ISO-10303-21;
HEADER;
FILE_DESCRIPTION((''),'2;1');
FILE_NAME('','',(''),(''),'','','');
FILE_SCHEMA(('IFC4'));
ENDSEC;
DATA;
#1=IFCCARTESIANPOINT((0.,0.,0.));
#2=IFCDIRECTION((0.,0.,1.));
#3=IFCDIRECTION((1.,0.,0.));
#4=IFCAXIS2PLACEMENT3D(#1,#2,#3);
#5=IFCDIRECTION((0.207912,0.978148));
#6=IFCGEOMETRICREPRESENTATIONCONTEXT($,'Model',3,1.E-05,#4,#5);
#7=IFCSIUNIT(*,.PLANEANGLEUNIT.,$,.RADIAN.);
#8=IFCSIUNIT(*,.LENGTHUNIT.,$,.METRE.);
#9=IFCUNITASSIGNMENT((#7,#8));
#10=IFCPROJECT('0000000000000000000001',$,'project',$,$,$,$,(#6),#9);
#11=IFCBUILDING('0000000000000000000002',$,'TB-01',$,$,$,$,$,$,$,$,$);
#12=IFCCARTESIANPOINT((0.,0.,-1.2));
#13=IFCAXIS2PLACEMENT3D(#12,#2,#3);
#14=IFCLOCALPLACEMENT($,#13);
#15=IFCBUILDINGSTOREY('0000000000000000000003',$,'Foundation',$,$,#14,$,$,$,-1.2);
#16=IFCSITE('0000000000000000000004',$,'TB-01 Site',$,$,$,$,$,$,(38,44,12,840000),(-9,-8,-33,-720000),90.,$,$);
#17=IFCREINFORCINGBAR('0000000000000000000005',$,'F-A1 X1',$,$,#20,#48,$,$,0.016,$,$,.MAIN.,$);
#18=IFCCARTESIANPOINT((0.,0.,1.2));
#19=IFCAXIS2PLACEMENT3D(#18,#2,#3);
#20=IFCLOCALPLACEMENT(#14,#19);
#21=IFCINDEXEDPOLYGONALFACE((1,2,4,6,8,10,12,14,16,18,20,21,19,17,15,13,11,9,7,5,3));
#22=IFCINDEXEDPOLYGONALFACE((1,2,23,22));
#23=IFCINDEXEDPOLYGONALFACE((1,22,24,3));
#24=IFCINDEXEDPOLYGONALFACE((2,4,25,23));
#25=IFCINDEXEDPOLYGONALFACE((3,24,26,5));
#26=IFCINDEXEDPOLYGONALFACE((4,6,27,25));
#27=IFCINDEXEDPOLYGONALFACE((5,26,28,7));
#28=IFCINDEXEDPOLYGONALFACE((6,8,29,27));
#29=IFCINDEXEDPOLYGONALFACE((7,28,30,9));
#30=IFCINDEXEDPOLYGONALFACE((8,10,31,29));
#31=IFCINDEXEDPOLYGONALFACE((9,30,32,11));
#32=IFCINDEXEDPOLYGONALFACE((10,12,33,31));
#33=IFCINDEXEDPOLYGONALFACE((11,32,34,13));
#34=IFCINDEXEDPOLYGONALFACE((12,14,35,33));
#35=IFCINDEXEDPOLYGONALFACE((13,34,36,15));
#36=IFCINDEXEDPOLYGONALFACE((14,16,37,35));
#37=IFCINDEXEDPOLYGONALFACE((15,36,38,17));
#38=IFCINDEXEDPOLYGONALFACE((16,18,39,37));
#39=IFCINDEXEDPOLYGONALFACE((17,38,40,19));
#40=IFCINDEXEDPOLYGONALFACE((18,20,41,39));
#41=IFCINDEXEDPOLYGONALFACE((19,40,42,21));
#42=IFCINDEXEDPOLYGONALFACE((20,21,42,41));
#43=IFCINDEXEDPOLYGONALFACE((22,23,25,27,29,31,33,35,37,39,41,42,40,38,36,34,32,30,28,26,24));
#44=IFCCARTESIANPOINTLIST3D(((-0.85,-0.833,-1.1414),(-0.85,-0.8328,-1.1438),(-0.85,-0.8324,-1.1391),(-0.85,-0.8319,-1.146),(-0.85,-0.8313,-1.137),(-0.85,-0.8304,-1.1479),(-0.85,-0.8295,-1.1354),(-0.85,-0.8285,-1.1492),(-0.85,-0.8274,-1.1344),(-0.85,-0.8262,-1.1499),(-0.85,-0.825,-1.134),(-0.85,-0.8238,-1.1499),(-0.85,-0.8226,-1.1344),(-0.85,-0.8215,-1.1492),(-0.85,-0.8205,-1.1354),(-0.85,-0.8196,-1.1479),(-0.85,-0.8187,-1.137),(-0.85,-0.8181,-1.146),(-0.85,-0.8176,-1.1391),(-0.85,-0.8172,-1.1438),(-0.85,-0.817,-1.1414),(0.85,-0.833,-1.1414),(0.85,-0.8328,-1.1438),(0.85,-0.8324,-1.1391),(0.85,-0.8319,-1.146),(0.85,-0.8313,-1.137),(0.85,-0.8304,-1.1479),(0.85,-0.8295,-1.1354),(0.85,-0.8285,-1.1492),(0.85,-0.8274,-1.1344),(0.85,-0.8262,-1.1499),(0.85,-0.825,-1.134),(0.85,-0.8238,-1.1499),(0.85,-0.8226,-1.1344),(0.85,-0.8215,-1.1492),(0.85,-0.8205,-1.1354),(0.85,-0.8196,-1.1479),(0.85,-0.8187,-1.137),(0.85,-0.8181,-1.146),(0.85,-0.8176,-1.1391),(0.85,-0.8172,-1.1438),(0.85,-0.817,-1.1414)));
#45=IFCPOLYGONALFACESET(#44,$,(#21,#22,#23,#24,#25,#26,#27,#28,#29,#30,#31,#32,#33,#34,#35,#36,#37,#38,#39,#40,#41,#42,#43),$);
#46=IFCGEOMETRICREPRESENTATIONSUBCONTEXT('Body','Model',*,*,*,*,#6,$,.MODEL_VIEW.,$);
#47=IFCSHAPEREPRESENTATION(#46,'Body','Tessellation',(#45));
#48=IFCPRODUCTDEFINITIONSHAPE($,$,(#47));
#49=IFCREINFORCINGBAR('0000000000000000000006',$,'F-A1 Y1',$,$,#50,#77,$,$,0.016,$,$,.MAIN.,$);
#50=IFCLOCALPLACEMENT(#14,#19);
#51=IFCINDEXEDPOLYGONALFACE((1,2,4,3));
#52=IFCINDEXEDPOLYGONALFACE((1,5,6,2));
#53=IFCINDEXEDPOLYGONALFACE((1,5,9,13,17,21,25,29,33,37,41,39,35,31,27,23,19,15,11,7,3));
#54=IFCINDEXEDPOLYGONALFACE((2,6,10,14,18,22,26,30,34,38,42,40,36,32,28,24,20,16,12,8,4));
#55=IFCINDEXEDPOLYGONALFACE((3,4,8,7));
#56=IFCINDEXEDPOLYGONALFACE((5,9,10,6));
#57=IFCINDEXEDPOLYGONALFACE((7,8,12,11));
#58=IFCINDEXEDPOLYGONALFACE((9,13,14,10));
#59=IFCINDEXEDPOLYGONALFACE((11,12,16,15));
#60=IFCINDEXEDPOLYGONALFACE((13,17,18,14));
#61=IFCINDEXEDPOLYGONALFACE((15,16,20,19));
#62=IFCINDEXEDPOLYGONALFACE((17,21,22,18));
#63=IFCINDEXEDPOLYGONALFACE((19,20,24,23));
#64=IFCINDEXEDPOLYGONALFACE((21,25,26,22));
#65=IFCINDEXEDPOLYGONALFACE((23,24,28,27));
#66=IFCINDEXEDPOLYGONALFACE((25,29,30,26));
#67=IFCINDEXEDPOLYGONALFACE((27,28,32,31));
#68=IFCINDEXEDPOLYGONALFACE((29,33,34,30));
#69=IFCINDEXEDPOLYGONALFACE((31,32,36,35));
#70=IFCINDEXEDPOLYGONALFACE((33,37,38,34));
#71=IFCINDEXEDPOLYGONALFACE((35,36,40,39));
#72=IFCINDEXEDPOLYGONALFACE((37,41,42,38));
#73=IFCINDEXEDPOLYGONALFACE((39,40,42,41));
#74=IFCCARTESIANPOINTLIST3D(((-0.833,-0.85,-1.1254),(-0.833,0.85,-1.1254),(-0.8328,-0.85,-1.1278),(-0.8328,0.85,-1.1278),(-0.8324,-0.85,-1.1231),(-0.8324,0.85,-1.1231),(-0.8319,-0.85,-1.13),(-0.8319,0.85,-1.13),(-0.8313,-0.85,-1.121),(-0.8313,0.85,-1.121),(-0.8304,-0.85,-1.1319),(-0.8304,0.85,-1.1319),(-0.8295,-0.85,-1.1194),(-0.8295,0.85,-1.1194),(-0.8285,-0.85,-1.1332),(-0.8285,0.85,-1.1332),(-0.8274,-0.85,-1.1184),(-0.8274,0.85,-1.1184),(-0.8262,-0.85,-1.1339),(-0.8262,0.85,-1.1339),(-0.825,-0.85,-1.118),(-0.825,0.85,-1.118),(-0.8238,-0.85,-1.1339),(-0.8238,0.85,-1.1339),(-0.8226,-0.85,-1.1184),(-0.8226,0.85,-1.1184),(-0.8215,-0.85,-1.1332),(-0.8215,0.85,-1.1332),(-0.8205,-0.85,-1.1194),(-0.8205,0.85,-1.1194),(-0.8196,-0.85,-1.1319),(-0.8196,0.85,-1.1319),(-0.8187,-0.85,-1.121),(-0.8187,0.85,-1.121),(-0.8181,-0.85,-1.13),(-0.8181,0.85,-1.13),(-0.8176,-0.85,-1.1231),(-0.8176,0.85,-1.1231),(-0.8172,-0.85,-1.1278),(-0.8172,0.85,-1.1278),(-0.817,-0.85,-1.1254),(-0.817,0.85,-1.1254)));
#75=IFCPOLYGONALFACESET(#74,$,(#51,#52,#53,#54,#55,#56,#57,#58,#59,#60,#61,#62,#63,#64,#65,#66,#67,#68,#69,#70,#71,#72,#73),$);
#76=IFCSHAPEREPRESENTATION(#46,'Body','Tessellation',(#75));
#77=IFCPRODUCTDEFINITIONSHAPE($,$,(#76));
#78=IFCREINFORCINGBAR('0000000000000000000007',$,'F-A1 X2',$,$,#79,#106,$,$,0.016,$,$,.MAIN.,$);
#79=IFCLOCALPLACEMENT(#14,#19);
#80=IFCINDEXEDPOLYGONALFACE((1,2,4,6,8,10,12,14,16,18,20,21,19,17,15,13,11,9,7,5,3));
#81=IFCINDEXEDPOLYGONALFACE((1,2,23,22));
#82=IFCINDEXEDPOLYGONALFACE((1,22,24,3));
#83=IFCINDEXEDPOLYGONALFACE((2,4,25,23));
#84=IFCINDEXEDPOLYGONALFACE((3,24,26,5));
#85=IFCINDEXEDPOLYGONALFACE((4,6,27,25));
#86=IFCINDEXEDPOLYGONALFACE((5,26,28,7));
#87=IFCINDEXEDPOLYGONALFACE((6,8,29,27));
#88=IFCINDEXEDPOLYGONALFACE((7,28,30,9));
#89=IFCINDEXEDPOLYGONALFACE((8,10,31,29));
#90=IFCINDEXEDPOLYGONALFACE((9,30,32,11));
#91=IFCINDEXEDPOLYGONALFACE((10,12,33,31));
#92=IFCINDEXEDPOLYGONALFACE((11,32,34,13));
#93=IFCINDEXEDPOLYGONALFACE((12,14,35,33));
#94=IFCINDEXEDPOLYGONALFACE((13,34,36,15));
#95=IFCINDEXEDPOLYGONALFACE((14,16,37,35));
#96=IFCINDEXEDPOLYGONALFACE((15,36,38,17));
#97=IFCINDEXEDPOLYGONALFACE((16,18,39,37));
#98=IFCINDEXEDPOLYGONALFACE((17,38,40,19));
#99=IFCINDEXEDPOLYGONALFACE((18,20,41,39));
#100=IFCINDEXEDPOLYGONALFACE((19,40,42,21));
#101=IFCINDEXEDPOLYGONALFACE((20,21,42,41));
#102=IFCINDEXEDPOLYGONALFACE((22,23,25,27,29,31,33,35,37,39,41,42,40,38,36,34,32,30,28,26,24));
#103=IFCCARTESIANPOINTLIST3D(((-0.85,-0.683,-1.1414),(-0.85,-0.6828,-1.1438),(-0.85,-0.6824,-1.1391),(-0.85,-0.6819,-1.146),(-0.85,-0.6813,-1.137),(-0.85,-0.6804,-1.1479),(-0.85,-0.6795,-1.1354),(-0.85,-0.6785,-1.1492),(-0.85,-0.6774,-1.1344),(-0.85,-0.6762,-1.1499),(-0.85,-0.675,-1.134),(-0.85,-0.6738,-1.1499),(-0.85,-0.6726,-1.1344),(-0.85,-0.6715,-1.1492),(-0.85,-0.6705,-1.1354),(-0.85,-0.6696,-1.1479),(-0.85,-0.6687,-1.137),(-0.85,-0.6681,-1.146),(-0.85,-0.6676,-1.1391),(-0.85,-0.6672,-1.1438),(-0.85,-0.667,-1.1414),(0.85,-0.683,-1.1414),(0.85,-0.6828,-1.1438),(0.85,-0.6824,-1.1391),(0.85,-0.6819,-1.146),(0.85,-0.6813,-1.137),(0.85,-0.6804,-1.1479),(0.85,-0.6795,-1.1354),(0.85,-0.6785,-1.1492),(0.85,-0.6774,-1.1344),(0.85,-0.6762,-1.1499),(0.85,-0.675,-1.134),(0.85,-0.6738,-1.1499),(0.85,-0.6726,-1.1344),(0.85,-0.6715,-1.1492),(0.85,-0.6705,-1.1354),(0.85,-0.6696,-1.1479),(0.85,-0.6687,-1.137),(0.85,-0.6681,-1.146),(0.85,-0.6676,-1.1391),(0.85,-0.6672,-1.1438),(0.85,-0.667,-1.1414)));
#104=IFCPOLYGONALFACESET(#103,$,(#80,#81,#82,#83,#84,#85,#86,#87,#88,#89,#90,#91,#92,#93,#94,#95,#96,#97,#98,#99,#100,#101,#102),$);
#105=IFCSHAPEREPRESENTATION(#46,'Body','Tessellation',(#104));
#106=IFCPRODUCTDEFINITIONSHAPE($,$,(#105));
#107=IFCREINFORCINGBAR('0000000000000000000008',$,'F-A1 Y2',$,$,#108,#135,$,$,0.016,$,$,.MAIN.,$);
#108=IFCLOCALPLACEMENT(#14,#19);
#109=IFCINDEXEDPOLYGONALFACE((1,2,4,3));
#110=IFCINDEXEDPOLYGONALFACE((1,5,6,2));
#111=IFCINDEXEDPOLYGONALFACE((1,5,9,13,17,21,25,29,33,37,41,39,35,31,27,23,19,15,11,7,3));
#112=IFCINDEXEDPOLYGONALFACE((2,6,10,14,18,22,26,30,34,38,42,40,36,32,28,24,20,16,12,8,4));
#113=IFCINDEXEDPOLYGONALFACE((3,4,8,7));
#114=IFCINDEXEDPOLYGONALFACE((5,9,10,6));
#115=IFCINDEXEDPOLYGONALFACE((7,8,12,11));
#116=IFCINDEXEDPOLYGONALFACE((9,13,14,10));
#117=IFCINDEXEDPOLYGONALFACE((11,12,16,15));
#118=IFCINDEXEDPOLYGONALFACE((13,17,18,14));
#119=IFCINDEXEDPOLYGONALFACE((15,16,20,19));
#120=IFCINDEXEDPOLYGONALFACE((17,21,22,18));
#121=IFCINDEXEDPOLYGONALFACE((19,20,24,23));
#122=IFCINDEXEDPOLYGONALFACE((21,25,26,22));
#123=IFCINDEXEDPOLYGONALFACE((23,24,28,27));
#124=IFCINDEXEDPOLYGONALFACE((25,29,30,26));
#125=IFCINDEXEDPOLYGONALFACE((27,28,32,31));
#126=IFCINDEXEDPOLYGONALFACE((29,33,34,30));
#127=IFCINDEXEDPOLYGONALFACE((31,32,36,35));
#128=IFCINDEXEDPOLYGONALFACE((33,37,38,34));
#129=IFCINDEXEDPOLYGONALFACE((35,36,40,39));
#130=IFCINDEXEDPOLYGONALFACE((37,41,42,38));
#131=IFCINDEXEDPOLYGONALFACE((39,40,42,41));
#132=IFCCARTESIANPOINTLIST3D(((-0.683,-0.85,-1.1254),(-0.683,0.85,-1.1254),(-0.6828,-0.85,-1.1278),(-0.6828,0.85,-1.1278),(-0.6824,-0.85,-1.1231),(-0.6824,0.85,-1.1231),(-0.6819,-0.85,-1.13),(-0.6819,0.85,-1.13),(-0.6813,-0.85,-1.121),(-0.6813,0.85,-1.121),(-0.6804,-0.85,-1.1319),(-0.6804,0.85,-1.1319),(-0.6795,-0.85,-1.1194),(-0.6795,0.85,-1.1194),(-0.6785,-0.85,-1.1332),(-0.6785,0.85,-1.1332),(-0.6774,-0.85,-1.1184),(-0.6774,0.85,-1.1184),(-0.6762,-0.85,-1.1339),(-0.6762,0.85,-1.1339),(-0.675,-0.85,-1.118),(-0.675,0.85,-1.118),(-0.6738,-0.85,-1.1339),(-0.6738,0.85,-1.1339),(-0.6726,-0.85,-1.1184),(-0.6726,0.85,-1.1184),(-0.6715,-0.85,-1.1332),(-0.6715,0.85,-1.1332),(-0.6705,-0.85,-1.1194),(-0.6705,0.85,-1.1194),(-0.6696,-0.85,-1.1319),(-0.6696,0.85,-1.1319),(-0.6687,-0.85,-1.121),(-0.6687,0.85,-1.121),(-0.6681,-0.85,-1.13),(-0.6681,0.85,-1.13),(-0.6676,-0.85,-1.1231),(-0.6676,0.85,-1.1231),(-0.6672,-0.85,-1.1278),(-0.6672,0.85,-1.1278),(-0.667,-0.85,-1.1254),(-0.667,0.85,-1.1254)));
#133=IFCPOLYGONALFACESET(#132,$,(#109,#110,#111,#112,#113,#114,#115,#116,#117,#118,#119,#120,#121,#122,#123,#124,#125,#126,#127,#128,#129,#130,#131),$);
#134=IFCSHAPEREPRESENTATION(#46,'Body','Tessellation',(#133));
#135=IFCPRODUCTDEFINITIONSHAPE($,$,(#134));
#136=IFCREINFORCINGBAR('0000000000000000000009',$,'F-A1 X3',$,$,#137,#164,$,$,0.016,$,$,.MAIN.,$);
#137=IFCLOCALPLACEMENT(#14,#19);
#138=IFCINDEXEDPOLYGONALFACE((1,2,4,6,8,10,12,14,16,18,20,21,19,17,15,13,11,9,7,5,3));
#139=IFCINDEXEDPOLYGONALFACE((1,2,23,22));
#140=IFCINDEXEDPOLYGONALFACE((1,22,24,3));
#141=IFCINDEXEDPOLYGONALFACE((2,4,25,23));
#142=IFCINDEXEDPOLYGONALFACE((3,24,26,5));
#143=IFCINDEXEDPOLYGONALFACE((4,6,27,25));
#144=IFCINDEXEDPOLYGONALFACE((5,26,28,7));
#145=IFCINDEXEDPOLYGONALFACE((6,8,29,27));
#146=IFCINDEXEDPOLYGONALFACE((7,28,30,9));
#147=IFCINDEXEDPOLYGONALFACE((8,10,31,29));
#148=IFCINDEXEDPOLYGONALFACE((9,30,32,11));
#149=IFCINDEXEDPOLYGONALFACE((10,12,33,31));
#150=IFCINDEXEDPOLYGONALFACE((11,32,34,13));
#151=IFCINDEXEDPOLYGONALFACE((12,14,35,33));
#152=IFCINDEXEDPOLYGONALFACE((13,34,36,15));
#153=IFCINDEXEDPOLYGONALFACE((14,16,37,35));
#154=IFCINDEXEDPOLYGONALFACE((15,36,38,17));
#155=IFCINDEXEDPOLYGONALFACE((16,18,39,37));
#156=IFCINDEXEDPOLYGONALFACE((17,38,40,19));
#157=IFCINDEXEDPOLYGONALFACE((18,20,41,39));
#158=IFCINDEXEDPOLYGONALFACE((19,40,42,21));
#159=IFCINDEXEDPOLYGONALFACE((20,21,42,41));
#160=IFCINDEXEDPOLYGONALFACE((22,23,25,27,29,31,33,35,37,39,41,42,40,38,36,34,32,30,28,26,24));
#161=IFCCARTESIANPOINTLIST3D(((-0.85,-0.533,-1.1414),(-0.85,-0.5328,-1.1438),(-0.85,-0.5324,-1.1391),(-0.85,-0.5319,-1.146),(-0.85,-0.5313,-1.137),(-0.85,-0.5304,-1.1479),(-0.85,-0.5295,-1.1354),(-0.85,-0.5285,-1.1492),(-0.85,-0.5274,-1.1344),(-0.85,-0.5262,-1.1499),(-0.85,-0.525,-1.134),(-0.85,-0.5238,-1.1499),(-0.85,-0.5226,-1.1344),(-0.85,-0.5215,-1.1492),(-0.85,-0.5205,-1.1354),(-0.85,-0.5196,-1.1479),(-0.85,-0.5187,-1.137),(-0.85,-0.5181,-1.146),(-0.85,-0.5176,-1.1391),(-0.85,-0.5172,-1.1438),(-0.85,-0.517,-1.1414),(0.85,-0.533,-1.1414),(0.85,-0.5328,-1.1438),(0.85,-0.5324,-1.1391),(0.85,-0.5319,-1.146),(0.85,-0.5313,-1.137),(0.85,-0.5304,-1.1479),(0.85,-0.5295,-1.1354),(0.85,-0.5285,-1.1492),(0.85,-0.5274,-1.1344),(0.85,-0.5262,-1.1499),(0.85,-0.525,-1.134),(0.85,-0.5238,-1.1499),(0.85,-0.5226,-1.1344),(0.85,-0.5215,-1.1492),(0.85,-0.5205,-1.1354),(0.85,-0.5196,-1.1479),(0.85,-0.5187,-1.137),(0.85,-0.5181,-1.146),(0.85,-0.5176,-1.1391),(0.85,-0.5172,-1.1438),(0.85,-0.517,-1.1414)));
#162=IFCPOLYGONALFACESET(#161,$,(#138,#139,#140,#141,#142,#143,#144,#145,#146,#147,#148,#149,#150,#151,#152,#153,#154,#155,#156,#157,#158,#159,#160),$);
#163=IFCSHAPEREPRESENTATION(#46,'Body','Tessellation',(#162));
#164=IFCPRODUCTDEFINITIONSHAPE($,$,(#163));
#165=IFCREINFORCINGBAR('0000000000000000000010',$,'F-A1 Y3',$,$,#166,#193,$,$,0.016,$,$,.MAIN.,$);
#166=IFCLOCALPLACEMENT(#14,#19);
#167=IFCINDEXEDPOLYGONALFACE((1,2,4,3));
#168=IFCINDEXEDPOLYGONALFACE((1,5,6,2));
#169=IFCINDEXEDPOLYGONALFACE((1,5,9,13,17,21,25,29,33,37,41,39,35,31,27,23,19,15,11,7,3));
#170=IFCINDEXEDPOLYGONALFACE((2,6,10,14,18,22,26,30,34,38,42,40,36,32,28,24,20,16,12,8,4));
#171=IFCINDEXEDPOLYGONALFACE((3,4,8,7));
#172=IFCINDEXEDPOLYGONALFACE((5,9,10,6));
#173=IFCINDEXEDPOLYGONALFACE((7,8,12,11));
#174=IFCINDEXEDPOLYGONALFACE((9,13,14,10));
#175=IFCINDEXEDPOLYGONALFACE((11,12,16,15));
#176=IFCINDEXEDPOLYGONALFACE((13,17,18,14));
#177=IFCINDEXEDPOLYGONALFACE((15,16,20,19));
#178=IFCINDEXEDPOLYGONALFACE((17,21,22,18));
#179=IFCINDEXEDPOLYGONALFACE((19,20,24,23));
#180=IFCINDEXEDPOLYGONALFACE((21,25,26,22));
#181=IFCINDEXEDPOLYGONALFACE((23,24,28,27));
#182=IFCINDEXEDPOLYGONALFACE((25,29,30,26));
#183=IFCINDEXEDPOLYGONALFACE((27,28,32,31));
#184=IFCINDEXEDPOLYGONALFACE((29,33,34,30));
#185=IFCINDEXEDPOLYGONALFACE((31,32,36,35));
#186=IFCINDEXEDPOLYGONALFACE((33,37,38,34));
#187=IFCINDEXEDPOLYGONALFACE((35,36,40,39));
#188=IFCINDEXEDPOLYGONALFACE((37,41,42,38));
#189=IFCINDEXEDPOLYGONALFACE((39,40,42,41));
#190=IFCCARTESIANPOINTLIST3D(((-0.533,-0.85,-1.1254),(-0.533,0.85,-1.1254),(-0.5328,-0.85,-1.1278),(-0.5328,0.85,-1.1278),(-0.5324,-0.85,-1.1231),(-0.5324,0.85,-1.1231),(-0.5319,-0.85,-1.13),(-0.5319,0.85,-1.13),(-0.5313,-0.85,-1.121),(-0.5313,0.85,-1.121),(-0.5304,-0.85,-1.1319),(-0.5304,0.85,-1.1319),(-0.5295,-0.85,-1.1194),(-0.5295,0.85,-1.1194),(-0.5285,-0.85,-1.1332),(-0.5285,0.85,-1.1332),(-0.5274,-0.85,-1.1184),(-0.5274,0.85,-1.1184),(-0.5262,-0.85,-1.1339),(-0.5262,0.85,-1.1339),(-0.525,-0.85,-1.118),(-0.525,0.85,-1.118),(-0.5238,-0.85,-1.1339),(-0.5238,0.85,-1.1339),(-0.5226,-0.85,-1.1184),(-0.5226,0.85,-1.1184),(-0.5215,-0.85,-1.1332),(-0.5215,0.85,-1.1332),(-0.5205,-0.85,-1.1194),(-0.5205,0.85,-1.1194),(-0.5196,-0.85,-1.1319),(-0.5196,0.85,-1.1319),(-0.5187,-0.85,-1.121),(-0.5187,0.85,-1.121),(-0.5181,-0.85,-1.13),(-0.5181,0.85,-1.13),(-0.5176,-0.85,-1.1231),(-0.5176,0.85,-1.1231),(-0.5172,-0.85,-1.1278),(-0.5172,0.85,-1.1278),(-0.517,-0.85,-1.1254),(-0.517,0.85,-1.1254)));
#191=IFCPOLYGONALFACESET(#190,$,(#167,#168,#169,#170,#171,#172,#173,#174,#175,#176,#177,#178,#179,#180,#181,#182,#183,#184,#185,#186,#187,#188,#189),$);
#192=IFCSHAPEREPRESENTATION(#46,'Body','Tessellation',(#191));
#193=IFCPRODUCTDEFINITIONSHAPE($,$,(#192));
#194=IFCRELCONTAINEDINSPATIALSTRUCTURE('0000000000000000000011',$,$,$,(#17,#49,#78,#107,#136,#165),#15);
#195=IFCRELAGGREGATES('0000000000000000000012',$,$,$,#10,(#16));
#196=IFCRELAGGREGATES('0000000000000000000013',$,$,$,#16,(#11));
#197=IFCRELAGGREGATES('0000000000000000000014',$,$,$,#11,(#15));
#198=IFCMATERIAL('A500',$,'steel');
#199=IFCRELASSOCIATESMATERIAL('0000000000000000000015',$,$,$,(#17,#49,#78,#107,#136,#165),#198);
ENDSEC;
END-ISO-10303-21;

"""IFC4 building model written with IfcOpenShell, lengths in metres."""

from ifc_helpers import new_model, entity, si_unit, direction, frame, origin_with_axes, place, context, subcontext, project, spatial, material, element, save


model = new_model("IFC4")

# Units and contexts
model_context = context("Model", 3, precision=1e-05, world=origin_with_axes(), true_north=direction((0.207912, 0.978148)))
body_context = subcontext(model_context, "Body", "Model", "MODEL_VIEW")
ifc_project = project(units=[si_unit("PLANEANGLEUNIT", "RADIAN"), si_unit("LENGTHUNIT", "METRE")], contexts=[model_context])

# Site, building, storey
site = spatial("IfcSite", under=ifc_project, Name="TB-01 Site", RefLatitude=(38, 44, 12, 840000), RefLongitude=(-9, -8, -33, -720000), RefElevation=90.0)
building = spatial("IfcBuilding", under=site, Name="TB-01")
storey_placement = place(None, frame((0.0, 0.0, -1.2), z_axis=(0.0, 0.0, 1.0), x_axis=(1.0, 0.0, 0.0)))
storey = spatial("IfcBuildingStorey", under=building, at=storey_placement, Name="Foundation", Elevation=-1.2)

# Reinforcing bars
ifc_material_1 = material(Name="A500", Category="steel")
reinforcing_bar_1_placement = place(storey_placement, frame((0.0, 0.0, 1.2), z_axis=(0.0, 0.0, 1.0), x_axis=(1.0, 0.0, 0.0)))
element("IfcReinforcingBar", 1, at=reinforcing_bar_1_placement, inside=storey, material=ifc_material_1, Name="F-A1 X1", NominalDiameter=0.016, PredefinedType="MAIN", context=body_context, shape_type="AdvancedSweptSolid", body=[
    entity("IfcSweptDiskSolid", entity("IfcPolyline", [entity("IfcCartesianPoint", [-0.85, -0.825, -1.142]), entity("IfcCartesianPoint", [0.85, -0.825, -1.142])]), 0.008),
])
reinforcing_bar_2_placement = place(storey_placement, frame((0.0, 0.0, 1.2), z_axis=(0.0, 0.0, 1.0), x_axis=(1.0, 0.0, 0.0)))
element("IfcReinforcingBar", 2, at=reinforcing_bar_2_placement, inside=storey, material=ifc_material_1, Name="F-A1 Y1", NominalDiameter=0.016, PredefinedType="MAIN", context=body_context, shape_type="AdvancedSweptSolid", body=[
    entity("IfcSweptDiskSolid", entity("IfcPolyline", [entity("IfcCartesianPoint", [-0.825, -0.85, -1.126]), entity("IfcCartesianPoint", [-0.825, 0.85, -1.126])]), 0.008),
])
reinforcing_bar_3_placement = place(storey_placement, frame((0.0, 0.0, 1.2), z_axis=(0.0, 0.0, 1.0), x_axis=(1.0, 0.0, 0.0)))
element("IfcReinforcingBar", 3, at=reinforcing_bar_3_placement, inside=storey, material=ifc_material_1, Name="F-A1 X2", NominalDiameter=0.016, PredefinedType="MAIN", context=body_context, shape_type="AdvancedSweptSolid", body=[
    entity("IfcSweptDiskSolid", entity("IfcPolyline", [entity("IfcCartesianPoint", [-0.85, -0.675, -1.142]), entity("IfcCartesianPoint", [0.85, -0.675, -1.142])]), 0.008),
])
reinforcing_bar_4_placement = place(storey_placement, frame((0.0, 0.0, 1.2), z_axis=(0.0, 0.0, 1.0), x_axis=(1.0, 0.0, 0.0)))
element("IfcReinforcingBar", 4, at=reinforcing_bar_4_placement, inside=storey, material=ifc_material_1, Name="F-A1 Y2", NominalDiameter=0.016, PredefinedType="MAIN", context=body_context, shape_type="AdvancedSweptSolid", body=[
    entity("IfcSweptDiskSolid", entity("IfcPolyline", [entity("IfcCartesianPoint", [-0.675, -0.85, -1.126]), entity("IfcCartesianPoint", [-0.675, 0.85, -1.126])]), 0.008),
])
reinforcing_bar_5_placement = place(storey_placement, frame((0.0, 0.0, 1.2), z_axis=(0.0, 0.0, 1.0), x_axis=(1.0, 0.0, 0.0)))
element("IfcReinforcingBar", 5, at=reinforcing_bar_5_placement, inside=storey, material=ifc_material_1, Name="F-A1 X3", NominalDiameter=0.016, PredefinedType="MAIN", context=body_context, shape_type="AdvancedSweptSolid", body=[
    entity("IfcSweptDiskSolid", entity("IfcPolyline", [entity("IfcCartesianPoint", [-0.85, -0.525, -1.142]), entity("IfcCartesianPoint", [0.85, -0.525, -1.142])]), 0.008),
])
reinforcing_bar_6_placement = place(storey_placement, frame((0.0, 0.0, 1.2), z_axis=(0.0, 0.0, 1.0), x_axis=(1.0, 0.0, 0.0)))
element("IfcReinforcingBar", 6, at=reinforcing_bar_6_placement, inside=storey, material=ifc_material_1, Name="F-A1 Y3", NominalDiameter=0.016, PredefinedType="MAIN", context=body_context, shape_type="AdvancedSweptSolid", body=[
    entity("IfcSweptDiskSolid", entity("IfcPolyline", [entity("IfcCartesianPoint", [-0.525, -0.85, -1.126]), entity("IfcCartesianPoint", [-0.525, 0.85, -1.126])]), 0.008),
])

save(model, "model.ifc")
